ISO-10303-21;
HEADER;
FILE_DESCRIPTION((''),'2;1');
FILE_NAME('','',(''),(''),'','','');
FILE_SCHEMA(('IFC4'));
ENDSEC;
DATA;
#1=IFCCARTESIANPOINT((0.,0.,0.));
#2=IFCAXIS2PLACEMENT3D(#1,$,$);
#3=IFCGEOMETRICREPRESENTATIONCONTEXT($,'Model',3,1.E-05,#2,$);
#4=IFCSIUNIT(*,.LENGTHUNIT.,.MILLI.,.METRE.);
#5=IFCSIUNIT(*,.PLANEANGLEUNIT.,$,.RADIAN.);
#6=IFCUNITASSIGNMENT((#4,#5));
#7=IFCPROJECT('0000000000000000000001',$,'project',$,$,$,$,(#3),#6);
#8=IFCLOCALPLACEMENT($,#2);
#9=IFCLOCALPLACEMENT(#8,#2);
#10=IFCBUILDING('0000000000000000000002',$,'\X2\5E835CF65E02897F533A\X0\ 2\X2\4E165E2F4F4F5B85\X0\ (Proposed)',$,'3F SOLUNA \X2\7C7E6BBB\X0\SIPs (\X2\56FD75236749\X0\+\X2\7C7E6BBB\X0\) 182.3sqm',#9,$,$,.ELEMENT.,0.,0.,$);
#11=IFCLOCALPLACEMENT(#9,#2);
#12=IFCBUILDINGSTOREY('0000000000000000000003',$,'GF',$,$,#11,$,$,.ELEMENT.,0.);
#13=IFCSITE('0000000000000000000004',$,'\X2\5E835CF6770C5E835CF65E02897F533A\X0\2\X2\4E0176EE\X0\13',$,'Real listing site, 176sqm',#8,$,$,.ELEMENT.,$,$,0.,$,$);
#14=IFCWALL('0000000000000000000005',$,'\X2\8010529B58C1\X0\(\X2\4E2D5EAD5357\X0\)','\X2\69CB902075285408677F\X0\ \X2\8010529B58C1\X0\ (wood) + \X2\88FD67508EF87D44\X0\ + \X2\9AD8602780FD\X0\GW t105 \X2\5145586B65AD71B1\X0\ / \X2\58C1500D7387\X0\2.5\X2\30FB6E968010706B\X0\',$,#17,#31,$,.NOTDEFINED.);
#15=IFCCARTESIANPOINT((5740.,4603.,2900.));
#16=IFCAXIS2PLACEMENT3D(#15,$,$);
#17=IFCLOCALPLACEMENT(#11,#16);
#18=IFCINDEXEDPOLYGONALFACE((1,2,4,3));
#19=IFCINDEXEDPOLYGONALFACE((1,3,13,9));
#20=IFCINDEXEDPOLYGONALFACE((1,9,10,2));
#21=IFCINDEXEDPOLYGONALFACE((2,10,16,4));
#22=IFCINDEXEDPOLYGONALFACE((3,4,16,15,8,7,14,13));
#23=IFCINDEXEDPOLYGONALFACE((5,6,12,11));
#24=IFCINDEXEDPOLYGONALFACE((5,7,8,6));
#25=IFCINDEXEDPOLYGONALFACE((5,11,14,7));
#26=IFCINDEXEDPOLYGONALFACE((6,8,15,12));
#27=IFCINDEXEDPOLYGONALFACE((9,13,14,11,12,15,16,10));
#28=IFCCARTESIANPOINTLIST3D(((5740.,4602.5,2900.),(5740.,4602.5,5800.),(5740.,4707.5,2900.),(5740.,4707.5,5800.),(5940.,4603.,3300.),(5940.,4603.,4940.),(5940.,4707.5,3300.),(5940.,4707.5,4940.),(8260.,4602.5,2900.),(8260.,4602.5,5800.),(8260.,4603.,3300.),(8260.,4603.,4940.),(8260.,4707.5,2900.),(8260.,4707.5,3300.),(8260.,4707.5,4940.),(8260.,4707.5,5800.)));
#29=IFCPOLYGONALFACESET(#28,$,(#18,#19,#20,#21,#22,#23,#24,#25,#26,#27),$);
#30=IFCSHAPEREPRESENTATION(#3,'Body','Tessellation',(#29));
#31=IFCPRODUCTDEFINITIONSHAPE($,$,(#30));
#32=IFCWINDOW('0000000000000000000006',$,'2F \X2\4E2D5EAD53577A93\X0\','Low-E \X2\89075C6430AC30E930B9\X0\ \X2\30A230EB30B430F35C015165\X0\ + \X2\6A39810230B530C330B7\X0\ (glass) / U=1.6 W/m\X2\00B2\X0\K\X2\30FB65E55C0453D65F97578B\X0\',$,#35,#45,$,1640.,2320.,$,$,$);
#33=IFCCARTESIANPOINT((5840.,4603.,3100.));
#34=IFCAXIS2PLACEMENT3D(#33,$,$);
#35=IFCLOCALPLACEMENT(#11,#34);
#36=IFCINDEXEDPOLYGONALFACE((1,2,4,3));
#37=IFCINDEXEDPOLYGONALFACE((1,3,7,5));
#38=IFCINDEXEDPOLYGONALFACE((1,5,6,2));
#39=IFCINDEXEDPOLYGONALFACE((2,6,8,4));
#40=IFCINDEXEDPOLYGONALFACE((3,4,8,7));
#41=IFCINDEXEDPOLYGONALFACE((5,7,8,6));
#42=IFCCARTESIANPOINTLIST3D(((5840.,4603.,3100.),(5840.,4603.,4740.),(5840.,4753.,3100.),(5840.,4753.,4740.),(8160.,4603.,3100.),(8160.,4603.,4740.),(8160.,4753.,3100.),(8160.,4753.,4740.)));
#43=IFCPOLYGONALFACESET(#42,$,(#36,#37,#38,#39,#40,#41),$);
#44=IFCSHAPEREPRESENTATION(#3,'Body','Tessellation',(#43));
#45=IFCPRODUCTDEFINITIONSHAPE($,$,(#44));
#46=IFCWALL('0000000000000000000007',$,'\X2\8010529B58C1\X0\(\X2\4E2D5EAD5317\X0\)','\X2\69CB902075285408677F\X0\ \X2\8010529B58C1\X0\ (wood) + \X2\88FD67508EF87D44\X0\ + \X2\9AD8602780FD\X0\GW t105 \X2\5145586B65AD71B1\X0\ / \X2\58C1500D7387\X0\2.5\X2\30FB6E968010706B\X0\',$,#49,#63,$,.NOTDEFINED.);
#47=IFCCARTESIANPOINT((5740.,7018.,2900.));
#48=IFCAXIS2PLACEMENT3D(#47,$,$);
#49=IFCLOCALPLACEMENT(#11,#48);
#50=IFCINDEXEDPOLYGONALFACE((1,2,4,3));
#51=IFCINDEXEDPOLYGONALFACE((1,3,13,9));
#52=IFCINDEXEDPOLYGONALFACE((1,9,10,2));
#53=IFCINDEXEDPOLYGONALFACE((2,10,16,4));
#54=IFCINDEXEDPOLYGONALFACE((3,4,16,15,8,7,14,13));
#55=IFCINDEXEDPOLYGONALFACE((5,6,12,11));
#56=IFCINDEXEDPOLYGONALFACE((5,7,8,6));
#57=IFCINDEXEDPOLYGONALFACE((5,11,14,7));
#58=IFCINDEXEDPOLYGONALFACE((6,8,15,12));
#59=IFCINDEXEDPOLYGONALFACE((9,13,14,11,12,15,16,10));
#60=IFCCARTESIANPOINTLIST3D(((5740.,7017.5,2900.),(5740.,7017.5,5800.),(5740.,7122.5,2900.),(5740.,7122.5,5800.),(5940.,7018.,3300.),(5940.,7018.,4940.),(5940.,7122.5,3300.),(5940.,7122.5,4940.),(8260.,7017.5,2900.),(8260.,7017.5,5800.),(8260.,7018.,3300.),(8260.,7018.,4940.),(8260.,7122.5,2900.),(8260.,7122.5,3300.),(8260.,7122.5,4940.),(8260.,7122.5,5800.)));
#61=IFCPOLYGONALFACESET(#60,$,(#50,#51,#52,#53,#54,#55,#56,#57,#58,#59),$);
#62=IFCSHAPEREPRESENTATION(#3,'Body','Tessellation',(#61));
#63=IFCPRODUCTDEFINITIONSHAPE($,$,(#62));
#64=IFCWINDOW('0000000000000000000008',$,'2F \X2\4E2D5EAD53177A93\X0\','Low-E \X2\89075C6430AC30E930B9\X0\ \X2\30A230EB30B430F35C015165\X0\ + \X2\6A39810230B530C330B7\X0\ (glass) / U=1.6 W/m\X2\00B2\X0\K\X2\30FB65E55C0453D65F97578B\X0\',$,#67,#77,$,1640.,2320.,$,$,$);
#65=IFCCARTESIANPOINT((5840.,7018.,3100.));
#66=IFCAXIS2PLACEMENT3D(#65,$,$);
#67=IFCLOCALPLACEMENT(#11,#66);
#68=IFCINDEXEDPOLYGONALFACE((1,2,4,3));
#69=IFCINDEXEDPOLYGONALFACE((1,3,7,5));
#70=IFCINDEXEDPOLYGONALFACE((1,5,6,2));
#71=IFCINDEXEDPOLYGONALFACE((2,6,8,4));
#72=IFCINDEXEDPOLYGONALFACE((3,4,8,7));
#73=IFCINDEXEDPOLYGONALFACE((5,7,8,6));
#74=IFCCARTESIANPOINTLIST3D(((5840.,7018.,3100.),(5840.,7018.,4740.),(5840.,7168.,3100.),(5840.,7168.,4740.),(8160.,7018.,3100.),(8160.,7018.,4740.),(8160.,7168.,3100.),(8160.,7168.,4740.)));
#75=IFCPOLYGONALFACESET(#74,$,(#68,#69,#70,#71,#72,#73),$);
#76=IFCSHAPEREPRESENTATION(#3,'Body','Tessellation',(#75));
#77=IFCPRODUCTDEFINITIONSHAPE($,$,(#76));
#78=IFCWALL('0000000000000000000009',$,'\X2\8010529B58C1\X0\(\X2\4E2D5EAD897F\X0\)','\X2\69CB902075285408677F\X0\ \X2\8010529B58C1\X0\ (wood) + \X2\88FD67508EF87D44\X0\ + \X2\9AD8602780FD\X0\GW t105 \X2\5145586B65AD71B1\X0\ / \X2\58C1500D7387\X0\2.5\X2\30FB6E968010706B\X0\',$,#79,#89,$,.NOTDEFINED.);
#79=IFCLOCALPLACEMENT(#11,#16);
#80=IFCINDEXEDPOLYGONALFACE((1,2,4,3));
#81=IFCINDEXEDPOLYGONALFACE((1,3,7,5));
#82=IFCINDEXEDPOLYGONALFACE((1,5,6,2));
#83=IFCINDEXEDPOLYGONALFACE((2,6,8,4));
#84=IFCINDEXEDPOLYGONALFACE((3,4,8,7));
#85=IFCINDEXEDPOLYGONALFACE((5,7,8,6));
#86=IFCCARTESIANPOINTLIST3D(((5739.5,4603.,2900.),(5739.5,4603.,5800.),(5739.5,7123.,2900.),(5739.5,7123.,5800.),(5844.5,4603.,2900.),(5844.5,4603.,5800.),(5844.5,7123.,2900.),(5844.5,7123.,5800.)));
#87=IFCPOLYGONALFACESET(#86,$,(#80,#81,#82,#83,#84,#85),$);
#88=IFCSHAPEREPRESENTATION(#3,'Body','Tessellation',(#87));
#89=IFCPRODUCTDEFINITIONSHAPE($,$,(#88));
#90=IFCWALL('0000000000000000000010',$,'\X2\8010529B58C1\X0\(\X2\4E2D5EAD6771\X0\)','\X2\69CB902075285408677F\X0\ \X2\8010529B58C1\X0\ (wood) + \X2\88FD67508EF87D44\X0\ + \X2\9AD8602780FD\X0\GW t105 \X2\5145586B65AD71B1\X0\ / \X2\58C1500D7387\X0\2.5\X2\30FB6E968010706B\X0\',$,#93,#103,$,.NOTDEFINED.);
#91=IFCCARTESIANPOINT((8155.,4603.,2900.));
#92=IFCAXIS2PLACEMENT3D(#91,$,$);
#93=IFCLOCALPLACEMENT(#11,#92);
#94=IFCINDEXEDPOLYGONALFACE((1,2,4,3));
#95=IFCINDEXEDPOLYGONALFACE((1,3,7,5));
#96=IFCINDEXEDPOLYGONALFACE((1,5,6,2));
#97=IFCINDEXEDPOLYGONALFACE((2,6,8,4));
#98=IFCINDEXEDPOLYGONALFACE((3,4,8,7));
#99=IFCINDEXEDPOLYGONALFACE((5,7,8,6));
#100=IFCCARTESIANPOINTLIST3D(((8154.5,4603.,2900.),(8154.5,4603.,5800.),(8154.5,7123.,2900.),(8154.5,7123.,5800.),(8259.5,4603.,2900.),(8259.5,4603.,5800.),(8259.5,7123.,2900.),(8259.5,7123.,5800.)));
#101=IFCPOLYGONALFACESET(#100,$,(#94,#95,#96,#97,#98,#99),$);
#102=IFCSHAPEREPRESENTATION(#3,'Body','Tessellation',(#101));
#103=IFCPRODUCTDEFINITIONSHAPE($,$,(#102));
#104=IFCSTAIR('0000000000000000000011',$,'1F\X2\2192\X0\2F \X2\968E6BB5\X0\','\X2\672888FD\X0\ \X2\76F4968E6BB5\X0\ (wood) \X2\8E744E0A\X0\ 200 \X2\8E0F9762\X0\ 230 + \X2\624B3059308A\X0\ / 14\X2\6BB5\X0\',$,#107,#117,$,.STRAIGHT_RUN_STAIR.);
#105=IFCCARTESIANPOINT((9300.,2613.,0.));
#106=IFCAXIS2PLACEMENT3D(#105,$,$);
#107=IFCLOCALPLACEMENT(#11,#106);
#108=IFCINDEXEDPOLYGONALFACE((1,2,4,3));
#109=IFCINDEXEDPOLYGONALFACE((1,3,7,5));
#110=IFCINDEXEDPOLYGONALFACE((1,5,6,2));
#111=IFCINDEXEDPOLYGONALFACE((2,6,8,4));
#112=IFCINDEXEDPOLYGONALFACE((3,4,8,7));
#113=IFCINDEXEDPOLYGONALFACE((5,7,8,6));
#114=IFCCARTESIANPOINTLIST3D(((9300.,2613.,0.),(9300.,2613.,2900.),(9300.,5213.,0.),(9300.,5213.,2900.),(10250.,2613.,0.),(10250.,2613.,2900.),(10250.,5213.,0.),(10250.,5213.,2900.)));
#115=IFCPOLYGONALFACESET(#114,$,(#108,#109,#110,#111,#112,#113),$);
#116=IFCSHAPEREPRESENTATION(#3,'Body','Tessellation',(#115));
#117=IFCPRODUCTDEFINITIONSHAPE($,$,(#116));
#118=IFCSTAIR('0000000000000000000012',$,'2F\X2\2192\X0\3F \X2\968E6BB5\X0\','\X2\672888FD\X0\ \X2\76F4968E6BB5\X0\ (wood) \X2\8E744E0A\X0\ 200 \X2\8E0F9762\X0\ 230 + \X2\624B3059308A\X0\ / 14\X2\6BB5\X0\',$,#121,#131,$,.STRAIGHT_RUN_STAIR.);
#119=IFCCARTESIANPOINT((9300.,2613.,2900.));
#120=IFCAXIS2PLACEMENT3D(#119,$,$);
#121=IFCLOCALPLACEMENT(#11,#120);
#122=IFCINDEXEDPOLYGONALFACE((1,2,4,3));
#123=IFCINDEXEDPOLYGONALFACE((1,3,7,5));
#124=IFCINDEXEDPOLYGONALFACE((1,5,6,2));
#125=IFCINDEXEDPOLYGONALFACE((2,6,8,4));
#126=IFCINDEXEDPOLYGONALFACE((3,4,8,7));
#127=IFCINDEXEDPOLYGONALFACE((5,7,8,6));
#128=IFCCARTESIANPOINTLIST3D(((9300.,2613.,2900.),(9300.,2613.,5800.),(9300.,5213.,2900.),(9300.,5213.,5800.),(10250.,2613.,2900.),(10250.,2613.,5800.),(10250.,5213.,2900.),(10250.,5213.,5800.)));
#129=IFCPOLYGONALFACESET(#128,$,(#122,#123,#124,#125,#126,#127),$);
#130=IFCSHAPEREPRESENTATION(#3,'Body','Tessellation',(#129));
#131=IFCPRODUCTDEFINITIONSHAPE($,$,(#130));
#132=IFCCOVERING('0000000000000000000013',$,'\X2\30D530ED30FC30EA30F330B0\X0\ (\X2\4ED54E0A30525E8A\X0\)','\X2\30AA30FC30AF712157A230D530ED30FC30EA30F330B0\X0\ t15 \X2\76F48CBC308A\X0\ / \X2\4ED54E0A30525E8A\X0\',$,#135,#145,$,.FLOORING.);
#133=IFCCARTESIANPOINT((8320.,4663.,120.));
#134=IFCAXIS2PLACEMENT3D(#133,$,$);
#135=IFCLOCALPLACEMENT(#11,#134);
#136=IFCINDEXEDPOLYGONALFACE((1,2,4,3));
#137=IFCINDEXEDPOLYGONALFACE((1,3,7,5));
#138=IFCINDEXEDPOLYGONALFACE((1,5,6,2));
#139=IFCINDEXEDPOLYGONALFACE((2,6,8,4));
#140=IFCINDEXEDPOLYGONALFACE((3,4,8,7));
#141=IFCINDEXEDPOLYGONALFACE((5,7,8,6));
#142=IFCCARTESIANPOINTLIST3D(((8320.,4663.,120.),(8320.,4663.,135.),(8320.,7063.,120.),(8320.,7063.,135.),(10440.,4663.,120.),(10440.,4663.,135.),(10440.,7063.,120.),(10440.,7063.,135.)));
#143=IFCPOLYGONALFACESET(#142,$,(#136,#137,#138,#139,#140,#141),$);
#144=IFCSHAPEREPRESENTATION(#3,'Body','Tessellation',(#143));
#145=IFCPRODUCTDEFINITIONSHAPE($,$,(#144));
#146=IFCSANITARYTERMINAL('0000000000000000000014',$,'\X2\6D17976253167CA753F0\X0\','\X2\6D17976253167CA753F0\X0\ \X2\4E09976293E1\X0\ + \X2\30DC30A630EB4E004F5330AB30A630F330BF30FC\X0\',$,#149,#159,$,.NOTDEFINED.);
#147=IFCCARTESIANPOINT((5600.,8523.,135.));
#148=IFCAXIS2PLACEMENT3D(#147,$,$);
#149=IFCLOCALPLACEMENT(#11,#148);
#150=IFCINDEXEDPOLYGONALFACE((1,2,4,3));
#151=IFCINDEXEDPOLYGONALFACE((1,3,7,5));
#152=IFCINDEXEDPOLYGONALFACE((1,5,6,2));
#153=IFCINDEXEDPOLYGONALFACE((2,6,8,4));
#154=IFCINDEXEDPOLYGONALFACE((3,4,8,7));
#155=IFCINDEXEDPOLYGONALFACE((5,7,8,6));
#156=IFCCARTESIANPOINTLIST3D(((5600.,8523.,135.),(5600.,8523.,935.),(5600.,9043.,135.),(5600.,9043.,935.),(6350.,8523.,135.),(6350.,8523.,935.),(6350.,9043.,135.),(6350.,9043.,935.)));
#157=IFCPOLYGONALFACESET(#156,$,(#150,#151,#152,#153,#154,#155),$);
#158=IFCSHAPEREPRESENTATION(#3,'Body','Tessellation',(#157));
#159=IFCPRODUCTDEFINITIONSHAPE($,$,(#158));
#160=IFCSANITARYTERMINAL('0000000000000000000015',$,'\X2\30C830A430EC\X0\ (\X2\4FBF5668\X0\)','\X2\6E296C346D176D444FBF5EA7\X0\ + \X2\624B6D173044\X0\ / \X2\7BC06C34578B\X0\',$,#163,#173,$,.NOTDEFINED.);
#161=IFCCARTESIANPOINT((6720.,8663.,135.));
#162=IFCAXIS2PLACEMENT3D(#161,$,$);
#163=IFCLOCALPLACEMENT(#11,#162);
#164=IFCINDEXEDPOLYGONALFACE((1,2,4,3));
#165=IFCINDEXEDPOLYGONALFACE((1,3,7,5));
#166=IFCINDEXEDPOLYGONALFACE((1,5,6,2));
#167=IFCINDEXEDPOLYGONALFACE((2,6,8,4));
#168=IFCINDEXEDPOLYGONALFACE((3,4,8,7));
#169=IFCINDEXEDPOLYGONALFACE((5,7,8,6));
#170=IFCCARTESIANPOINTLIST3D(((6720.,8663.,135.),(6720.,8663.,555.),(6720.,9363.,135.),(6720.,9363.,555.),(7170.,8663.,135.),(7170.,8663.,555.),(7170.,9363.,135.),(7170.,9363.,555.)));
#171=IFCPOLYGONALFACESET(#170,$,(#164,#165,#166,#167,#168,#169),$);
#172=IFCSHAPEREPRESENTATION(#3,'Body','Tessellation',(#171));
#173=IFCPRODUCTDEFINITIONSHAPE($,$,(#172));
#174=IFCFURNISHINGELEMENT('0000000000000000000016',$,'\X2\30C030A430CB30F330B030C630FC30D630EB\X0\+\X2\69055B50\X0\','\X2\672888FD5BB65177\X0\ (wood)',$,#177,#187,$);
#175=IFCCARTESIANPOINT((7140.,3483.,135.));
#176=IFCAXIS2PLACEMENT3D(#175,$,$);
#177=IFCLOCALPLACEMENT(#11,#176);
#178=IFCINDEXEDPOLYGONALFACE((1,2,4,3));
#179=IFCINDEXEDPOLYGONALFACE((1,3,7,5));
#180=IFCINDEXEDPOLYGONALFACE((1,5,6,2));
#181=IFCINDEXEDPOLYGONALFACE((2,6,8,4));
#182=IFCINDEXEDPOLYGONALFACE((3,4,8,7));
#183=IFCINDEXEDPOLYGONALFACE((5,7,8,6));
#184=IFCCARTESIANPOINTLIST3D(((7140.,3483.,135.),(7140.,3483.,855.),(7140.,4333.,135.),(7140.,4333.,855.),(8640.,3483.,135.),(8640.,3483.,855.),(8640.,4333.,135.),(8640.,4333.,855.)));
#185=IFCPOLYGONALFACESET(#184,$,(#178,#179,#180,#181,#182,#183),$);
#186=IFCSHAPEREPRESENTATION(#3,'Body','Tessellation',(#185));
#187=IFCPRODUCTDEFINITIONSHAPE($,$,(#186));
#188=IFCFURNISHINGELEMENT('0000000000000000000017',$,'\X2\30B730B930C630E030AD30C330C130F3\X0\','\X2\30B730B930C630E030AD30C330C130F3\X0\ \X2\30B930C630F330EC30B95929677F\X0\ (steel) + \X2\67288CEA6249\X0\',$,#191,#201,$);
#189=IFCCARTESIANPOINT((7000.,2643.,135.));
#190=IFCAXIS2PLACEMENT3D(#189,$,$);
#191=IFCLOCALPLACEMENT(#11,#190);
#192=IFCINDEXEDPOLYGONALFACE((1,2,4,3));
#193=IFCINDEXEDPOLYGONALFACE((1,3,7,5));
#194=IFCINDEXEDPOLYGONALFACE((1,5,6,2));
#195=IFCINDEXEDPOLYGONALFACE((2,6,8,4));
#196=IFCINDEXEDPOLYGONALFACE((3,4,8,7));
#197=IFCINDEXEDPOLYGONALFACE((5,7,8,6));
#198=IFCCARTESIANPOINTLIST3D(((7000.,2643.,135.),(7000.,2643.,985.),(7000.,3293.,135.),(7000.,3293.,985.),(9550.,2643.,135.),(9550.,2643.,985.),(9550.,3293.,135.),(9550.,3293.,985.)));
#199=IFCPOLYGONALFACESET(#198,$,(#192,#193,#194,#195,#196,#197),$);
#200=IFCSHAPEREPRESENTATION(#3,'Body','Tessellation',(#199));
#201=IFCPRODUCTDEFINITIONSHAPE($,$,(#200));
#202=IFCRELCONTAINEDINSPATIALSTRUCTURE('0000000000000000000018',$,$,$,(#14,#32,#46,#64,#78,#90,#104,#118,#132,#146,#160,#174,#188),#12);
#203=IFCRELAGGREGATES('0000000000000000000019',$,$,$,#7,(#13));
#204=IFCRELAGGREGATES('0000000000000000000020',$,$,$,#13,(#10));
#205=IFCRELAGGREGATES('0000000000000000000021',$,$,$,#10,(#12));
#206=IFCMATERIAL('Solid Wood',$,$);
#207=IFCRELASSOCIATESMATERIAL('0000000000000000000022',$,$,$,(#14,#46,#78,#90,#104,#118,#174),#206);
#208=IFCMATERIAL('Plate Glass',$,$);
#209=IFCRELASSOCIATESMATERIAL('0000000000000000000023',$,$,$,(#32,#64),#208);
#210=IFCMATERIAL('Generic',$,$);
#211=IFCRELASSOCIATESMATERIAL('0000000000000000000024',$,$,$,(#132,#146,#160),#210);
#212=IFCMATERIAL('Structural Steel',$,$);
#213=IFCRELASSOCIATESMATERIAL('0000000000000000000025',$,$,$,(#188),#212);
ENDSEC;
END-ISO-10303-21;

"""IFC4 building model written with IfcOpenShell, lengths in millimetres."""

from ifc_helpers import new_model, si_unit, frame, frame_2d, origin, place, context, project, spatial, rectangle, extrude, material, element, fill, save


model = new_model("IFC4")

# Units and contexts
model_context = context("Model", 3, precision=1e-05, world=origin())
ifc_project = project(units=[si_unit("LENGTHUNIT", "METRE", prefix="MILLI"), si_unit("PLANEANGLEUNIT", "RADIAN")], contexts=[model_context])

# Site, building, storey
site_placement = place(None, origin())
site = spatial("IfcSite", under=ifc_project, at=site_placement, Name="広島県広島市西区2丁目13", ObjectType="Real listing site, 176sqm", CompositionType="ELEMENT", RefElevation=0.0)
building_placement = place(site_placement, origin())
building = spatial("IfcBuilding", under=site, at=building_placement, Name="広島市西区 2世帯住宅 (Proposed)", ObjectType="3F SOLUNA 籾殻SIPs (国産杉+籾殻) 182.3sqm", CompositionType="ELEMENT", ElevationOfRefHeight=0.0, ElevationOfTerrain=0.0)
storey_placement = place(building_placement, origin())
storey = spatial("IfcBuildingStorey", under=building, at=storey_placement, Name="GF", CompositionType="ELEMENT", Elevation=0.0)

# Shared definitions
ifc_material_1 = material(Name="Solid Wood")

# Shared definitions
ifc_material_2 = material(Name="Plate Glass")

# Walls, openings, windows
wall_1_placement = place(storey_placement, frame((5740.0, 4603.0, 2900.0)))
wall_1 = element("IfcWall", 1, at=wall_1_placement, inside=storey, material=ifc_material_1, Name="耐力壁(中庭南)", Description="構造用合板 耐力壁 (wood) + 製材軸組 + 高性能GW t105 充填断熱 / 壁倍率2.5・準耐火", PredefinedType="NOTDEFINED", context=model_context, shape_type="SweptSolid", body=[
    extrude(rectangle(XDim=2520.0, YDim=105.0, at=frame_2d((1260.0, 52.0))), frame((5740.0, 4603.0, 2900.0)), (0.0, 0.0, 1.0), 2900.0),
])
opening_1_placement = place(storey_placement, frame((5840.0, 4603.0, 3100.0)))
opening_1 = element("IfcOpeningElement", 2, at=opening_1_placement, cuts=wall_1, PredefinedType="NOTDEFINED", context=model_context, shape_type="SweptSolid", body=[
    extrude(rectangle(XDim=2320.0, YDim=150.0, at=frame_2d((1160.0, 75.0))), frame((5840.0, 4603.0, 3100.0)), (0.0, 0.0, 1.0), 1640.0),
])
window_1_placement = place(storey_placement, frame((5840.0, 4603.0, 3100.0)))
window_1 = element("IfcWindow", 3, at=window_1_placement, inside=storey, material=ifc_material_2, Name="2F 中庭南窓", Description="Low-E 複層ガラス アルゴン封入 + 樹脂サッシ (glass) / U=1.6 W/m²K・日射取得型", OverallHeight=1640.0, OverallWidth=2320.0, context=model_context, shape_type="SweptSolid", body=[
    extrude(rectangle(XDim=2320.0, YDim=150.0, at=frame_2d((1160.0, 75.0))), frame((5840.0, 4603.0, 3100.0)), (0.0, 0.0, 1.0), 1640.0),
])
fill(opening_1, window_1)
wall_2_placement = place(storey_placement, frame((5740.0, 7018.0, 2900.0)))
wall_2 = element("IfcWall", 4, at=wall_2_placement, inside=storey, material=ifc_material_1, Name="耐力壁(中庭北)", Description="構造用合板 耐力壁 (wood) + 製材軸組 + 高性能GW t105 充填断熱 / 壁倍率2.5・準耐火", PredefinedType="NOTDEFINED", context=model_context, shape_type="SweptSolid", body=[
    extrude(rectangle(XDim=2520.0, YDim=105.0, at=frame_2d((1260.0, 52.0))), frame((5740.0, 7018.0, 2900.0)), (0.0, 0.0, 1.0), 2900.0),
])
opening_2_placement = place(storey_placement, frame((5840.0, 7018.0, 3100.0)))
opening_2 = element("IfcOpeningElement", 5, at=opening_2_placement, cuts=wall_2, PredefinedType="NOTDEFINED", context=model_context, shape_type="SweptSolid", body=[
    extrude(rectangle(XDim=2320.0, YDim=150.0, at=frame_2d((1160.0, 75.0))), frame((5840.0, 7018.0, 3100.0)), (0.0, 0.0, 1.0), 1640.0),
])
window_2_placement = place(storey_placement, frame((5840.0, 7018.0, 3100.0)))
window_2 = element("IfcWindow", 6, at=window_2_placement, inside=storey, material=ifc_material_2, Name="2F 中庭北窓", Description="Low-E 複層ガラス アルゴン封入 + 樹脂サッシ (glass) / U=1.6 W/m²K・日射取得型", OverallHeight=1640.0, OverallWidth=2320.0, context=model_context, shape_type="SweptSolid", body=[
    extrude(rectangle(XDim=2320.0, YDim=150.0, at=frame_2d((1160.0, 75.0))), frame((5840.0, 7018.0, 3100.0)), (0.0, 0.0, 1.0), 1640.0),
])
fill(opening_2, window_2)

# Walls
wall_3_placement = place(storey_placement, frame((5740.0, 4603.0, 2900.0)))
element("IfcWall", 7, at=wall_3_placement, inside=storey, material=ifc_material_1, Name="耐力壁(中庭西)", Description="構造用合板 耐力壁 (wood) + 製材軸組 + 高性能GW t105 充填断熱 / 壁倍率2.5・準耐火", PredefinedType="NOTDEFINED", context=model_context, shape_type="SweptSolid", body=[
    extrude(rectangle(XDim=105.0, YDim=2520.0, at=frame_2d((52.0, 1260.0))), frame((5740.0, 4603.0, 2900.0)), (0.0, 0.0, 1.0), 2900.0),
])
wall_4_placement = place(storey_placement, frame((8155.0, 4603.0, 2900.0)))
element("IfcWall", 8, at=wall_4_placement, inside=storey, material=ifc_material_1, Name="耐力壁(中庭東)", Description="構造用合板 耐力壁 (wood) + 製材軸組 + 高性能GW t105 充填断熱 / 壁倍率2.5・準耐火", PredefinedType="NOTDEFINED", context=model_context, shape_type="SweptSolid", body=[
    extrude(rectangle(XDim=105.0, YDim=2520.0, at=frame_2d((52.0, 1260.0))), frame((8155.0, 4603.0, 2900.0)), (0.0, 0.0, 1.0), 2900.0),
])

# Stairs
stair_1_placement = place(storey_placement, frame((9300.0, 2613.0, 0.0)))
element("IfcStair", 9, at=stair_1_placement, inside=storey, material=ifc_material_1, Name="1F→2F 階段", Description="木製 直階段 (wood) 蹴上 200 踏面 230 + 手すり / 14段", PredefinedType="STRAIGHT_RUN_STAIR", context=model_context, shape_type="SweptSolid", body=[
    extrude(rectangle(XDim=950.0, YDim=2600.0, at=frame_2d((475.0, 1300.0))), frame((9300.0, 2613.0, 0.0)), (0.0, 0.0, 1.0), 2900.0),
])
stair_2_placement = place(storey_placement, frame((9300.0, 2613.0, 2900.0)))
element("IfcStair", 10, at=stair_2_placement, inside=storey, material=ifc_material_1, Name="2F→3F 階段", Description="木製 直階段 (wood) 蹴上 200 踏面 230 + 手すり / 14段", PredefinedType="STRAIGHT_RUN_STAIR", context=model_context, shape_type="SweptSolid", body=[
    extrude(rectangle(XDim=950.0, YDim=2600.0, at=frame_2d((475.0, 1300.0))), frame((9300.0, 2613.0, 2900.0)), (0.0, 0.0, 1.0), 2900.0),
])

# Covering
ifc_material_3 = material(Name="Generic")
covering_placement = place(storey_placement, frame((8320.0, 4663.0, 120.0)))
element("IfcCovering", 11, at=covering_placement, inside=storey, material=ifc_material_3, Name="フローリング (仕上げ床)", Description="オーク無垢フローリング t15 直貼り / 仕上げ床", PredefinedType="FLOORING", context=model_context, shape_type="SweptSolid", body=[
    extrude(rectangle(XDim=2120.0, YDim=2400.0, at=frame_2d((1060.0, 1200.0))), frame((8320.0, 4663.0, 120.0)), (0.0, 0.0, 1.0), 15.0),
])

# Sanitary terminals
sanitary_terminal_1_placement = place(storey_placement, frame((5600.0, 8523.0, 135.0)))
element("IfcSanitaryTerminal", 12, at=sanitary_terminal_1_placement, inside=storey, material=ifc_material_3, Name="洗面化粧台", Description="洗面化粧台 三面鏡 + ボウル一体カウンター", PredefinedType="NOTDEFINED", context=model_context, shape_type="SweptSolid", body=[
    extrude(rectangle(XDim=750.0, YDim=520.0, at=frame_2d((375.0, 260.0))), frame((5600.0, 8523.0, 135.0)), (0.0, 0.0, 1.0), 800.0),
])
sanitary_terminal_2_placement = place(storey_placement, frame((6720.0, 8663.0, 135.0)))
element("IfcSanitaryTerminal", 13, at=sanitary_terminal_2_placement, inside=storey, material=ifc_material_3, Name="トイレ (便器)", Description="温水洗浄便座 + 手洗い / 節水型", PredefinedType="NOTDEFINED", context=model_context, shape_type="SweptSolid", body=[
    extrude(rectangle(XDim=450.0, YDim=700.0, at=frame_2d((225.0, 350.0))), frame((6720.0, 8663.0, 135.0)), (0.0, 0.0, 1.0), 420.0),
])

# Furnishing elements
furnishing_1_placement = place(storey_placement, frame((7140.0, 3483.0, 135.0)))
element("IfcFurnishingElement", 14, at=furnishing_1_placement, inside=storey, material=ifc_material_1, Name="ダイニングテーブル+椅子", Description="木製家具 (wood)", context=model_context, shape_type="SweptSolid", body=[
    extrude(rectangle(XDim=1500.0, YDim=850.0, at=frame_2d((750.0, 425.0))), frame((7140.0, 3483.0, 135.0)), (0.0, 0.0, 1.0), 720.0),
])
ifc_material_4 = material(Name="Structural Steel")
furnishing_2_placement = place(storey_placement, frame((7000.0, 2643.0, 135.0)))
element("IfcFurnishingElement", 15, at=furnishing_2_placement, inside=storey, material=ifc_material_4, Name="システムキッチン", Description="システムキッチン ステンレス天板 (steel) + 木質扉", context=model_context, shape_type="SweptSolid", body=[
    extrude(rectangle(XDim=2550.0, YDim=650.0, at=frame_2d((1275.0, 325.0))), frame((7000.0, 2643.0, 135.0)), (0.0, 0.0, 1.0), 850.0),
])

save(model, "model.ifc")
